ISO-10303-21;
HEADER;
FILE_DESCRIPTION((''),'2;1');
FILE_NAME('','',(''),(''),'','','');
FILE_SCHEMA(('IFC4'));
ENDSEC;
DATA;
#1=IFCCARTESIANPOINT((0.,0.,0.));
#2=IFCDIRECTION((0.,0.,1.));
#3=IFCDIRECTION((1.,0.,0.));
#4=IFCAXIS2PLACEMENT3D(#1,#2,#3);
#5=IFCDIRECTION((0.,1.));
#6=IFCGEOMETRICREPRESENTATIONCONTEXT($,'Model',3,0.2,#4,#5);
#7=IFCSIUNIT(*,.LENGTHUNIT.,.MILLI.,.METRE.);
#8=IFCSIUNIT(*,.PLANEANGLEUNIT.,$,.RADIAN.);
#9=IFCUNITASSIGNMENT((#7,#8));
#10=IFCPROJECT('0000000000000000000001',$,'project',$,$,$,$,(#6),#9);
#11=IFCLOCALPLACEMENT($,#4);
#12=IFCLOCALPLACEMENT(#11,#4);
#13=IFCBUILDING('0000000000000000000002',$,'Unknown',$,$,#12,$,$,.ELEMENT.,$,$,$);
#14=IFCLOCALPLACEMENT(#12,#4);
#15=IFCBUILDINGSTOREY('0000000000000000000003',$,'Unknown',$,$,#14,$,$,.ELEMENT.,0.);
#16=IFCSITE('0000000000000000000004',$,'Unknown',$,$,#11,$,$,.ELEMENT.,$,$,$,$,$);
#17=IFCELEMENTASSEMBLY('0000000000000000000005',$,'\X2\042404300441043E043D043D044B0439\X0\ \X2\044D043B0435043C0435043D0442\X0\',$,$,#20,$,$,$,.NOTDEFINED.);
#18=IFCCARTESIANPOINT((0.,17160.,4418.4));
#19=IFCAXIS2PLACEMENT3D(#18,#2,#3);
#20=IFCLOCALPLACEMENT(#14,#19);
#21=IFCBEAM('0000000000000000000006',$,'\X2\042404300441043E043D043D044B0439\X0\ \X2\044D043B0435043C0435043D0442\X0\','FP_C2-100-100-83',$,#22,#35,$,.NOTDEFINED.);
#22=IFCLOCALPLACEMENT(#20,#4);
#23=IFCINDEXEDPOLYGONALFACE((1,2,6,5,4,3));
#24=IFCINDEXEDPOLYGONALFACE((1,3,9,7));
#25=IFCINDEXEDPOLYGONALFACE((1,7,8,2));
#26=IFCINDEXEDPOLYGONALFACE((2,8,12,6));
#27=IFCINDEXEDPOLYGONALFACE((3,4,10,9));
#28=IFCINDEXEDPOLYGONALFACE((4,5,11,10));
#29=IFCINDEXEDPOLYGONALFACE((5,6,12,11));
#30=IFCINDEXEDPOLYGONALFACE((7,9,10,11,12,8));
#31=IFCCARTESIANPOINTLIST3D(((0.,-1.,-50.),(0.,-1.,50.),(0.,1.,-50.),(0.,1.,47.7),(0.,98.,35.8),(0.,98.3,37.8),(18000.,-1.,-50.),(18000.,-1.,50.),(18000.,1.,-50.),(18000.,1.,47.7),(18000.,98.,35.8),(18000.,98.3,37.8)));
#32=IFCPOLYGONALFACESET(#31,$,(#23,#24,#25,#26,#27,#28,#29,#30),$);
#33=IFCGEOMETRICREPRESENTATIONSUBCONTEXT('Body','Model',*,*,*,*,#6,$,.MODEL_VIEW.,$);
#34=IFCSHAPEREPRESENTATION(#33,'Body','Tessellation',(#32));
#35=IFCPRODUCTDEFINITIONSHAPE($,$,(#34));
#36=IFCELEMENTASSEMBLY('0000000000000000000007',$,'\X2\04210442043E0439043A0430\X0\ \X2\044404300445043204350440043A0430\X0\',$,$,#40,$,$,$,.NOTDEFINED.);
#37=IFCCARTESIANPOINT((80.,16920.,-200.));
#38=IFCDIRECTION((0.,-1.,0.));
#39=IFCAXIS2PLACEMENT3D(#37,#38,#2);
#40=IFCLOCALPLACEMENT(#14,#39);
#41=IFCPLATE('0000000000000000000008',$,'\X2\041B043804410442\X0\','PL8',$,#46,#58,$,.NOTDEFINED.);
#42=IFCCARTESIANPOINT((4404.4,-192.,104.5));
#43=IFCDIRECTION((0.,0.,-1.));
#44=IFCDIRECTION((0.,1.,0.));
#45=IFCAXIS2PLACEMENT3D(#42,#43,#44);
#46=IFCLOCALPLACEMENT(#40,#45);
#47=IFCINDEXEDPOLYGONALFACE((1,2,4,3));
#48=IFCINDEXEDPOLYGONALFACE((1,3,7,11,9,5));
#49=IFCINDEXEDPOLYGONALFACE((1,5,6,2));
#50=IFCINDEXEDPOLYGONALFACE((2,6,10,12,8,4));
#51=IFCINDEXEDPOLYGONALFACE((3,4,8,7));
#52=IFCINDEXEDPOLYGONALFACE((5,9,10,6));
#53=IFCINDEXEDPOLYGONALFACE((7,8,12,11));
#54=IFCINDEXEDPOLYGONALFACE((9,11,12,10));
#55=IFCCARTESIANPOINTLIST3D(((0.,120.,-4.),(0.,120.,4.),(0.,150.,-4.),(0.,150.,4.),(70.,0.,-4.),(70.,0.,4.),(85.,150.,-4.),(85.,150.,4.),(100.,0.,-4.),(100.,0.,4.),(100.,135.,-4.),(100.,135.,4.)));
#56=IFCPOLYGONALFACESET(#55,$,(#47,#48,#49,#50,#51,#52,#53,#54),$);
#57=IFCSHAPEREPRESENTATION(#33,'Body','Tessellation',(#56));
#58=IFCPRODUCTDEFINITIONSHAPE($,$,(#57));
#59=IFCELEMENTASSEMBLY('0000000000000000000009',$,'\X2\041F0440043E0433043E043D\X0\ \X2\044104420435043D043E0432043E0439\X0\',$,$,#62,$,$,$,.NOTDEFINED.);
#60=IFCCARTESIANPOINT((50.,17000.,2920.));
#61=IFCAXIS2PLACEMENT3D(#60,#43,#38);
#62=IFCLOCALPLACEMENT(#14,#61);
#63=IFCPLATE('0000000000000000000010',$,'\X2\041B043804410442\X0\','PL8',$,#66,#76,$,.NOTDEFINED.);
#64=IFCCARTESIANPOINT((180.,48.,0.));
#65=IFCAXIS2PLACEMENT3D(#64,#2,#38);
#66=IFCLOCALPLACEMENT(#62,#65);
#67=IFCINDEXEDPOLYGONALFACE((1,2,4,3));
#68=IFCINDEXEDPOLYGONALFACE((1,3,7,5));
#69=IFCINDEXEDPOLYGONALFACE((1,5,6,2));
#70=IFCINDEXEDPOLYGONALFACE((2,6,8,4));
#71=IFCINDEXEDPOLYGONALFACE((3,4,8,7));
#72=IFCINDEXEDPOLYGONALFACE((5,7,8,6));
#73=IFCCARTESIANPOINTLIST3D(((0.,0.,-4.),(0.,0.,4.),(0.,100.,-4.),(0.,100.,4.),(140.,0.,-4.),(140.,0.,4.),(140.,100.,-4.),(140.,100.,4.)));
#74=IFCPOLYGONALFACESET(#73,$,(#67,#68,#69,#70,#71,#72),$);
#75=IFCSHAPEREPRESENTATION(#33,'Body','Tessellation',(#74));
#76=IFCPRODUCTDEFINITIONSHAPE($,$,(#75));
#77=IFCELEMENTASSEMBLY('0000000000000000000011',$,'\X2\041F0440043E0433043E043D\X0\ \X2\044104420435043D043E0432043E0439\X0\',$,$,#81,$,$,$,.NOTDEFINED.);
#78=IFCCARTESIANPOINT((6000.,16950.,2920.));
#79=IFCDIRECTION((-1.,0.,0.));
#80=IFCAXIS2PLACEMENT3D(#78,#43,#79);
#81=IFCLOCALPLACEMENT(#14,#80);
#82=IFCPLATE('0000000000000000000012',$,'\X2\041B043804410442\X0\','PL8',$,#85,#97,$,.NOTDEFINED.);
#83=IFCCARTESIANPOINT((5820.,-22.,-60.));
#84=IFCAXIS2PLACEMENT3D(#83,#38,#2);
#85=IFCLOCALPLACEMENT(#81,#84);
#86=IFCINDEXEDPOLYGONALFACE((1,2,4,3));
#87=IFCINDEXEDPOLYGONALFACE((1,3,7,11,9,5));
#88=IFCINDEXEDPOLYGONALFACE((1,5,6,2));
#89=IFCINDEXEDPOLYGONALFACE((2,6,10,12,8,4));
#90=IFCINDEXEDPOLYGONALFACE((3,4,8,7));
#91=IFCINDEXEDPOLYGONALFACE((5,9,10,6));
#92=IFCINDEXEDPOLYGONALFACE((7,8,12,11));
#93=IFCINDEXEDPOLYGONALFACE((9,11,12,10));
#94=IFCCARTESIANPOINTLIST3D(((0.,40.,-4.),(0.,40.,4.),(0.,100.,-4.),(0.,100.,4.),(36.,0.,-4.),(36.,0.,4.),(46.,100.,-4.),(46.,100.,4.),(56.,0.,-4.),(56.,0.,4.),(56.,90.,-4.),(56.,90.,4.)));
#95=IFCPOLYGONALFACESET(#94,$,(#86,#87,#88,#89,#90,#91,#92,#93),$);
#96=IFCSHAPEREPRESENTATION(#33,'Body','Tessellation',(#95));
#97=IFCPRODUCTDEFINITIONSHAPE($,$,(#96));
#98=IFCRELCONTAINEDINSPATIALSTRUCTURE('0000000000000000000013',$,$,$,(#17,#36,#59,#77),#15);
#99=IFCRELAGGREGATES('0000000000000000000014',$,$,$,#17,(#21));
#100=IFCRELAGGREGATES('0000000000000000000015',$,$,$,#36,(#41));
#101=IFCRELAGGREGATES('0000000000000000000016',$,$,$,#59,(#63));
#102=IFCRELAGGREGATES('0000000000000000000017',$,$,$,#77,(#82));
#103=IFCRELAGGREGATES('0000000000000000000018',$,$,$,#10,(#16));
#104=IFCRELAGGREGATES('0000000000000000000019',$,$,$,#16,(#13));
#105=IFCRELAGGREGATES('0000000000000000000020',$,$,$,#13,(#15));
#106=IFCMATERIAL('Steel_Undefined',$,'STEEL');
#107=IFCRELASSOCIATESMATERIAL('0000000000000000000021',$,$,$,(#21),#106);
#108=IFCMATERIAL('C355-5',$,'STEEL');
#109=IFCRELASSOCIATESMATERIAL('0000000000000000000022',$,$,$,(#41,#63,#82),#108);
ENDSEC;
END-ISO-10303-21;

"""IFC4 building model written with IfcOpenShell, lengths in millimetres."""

from ifc_helpers import new_model, si_unit, direction, frame, origin_with_axes, place, context, subcontext, project, spatial, line, indexed_curve, outline, extrude, material, element, aggregate, save


model = new_model("IFC4")

# Units and contexts
model_context = context("Model", 3, precision=0.2, world=origin_with_axes(), true_north=direction((0.0, 1.0)))
body_context = subcontext(model_context, "Body", "Model", "MODEL_VIEW")
ifc_project = project(units=[si_unit("LENGTHUNIT", "METRE", prefix="MILLI"), si_unit("PLANEANGLEUNIT", "RADIAN")], contexts=[model_context])

# Site, building, storey
site_placement = place(None, origin_with_axes())
site = spatial("IfcSite", under=ifc_project, at=site_placement, Name="Unknown", CompositionType="ELEMENT")
building_placement = place(site_placement, origin_with_axes())
building = spatial("IfcBuilding", under=site, at=building_placement, Name="Unknown", CompositionType="ELEMENT")
storey_placement = place(building_placement, origin_with_axes())
storey = spatial("IfcBuildingStorey", under=building, at=storey_placement, Name="Unknown", CompositionType="ELEMENT", Elevation=0.0)

# Element assembly, beam
ifc_material_1 = material(Name="Steel_Undefined", Category="STEEL")
assembly_1_placement = place(storey_placement, frame((0.0, 17160.0, 4418.4), z_axis=(0.0, 0.0, 1.0), x_axis=(1.0, 0.0, 0.0)))
assembly_1 = element("IfcElementAssembly", 1, at=assembly_1_placement, inside=storey, Name="Фасонный элемент", PredefinedType="NOTDEFINED")
beam_1_placement = place(assembly_1_placement, origin_with_axes())
beam_1 = element("IfcBeam", 2, at=beam_1_placement, material=ifc_material_1, Name="Фасонный элемент", Description="FP_C2-100-100-83", PredefinedType="NOTDEFINED", context=body_context, shape_type="SolidModel", body=[
    extrude(outline(indexed_curve([(-50.0, -1.0), (50.0, -1.0), (37.8, 98.3), (35.8, 98.0), (47.7, 1.0), (-50.0, 1.0)], segments=[line(1, 2, 3, 4, 5, 6, 1)])), frame((0.0, 0.0, 0.0), z_axis=(-1.0, 0.0, 0.0), x_axis=(0.0, 0.0, 1.0)), (0.0, 0.0, -1.0), 18000.0),
])
aggregate(assembly_1, [beam_1])

# Element assembly, plate
assembly_2_placement = place(storey_placement, frame((80.0, 16920.0, -200.0), z_axis=(0.0, -1.0, 0.0), x_axis=(0.0, 0.0, 1.0)))
assembly_2 = element("IfcElementAssembly", 3, at=assembly_2_placement, inside=storey, Name="Стойка фахверка", PredefinedType="NOTDEFINED")
ifc_material_2 = material(Name="C355-5", Category="STEEL")
plate_1_placement = place(assembly_2_placement, frame((4404.4, -192.0, 104.5), z_axis=(0.0, 0.0, -1.0), x_axis=(0.0, 1.0, 0.0)))
plate_1 = element("IfcPlate", 4, at=plate_1_placement, material=ifc_material_2, Name="Лист", Description="PL8", PredefinedType="NOTDEFINED", context=body_context, shape_type="SolidModel", body=[
    extrude(outline(indexed_curve([(0.0, 120.0), (70.0, 0.0), (100.0, 0.0), (100.0, 135.0), (85.0, 150.0), (0.0, 150.0)], segments=[line(1, 2, 3, 4, 5, 6, 1)])), frame((0.0, 0.0, 4.0), z_axis=(0.0, 0.0, 1.0), x_axis=(1.0, 0.0, 0.0)), (0.0, 0.0, -1.0), 8.0),
])
aggregate(assembly_2, [plate_1])

# Element assemblies, plates
assembly_3_placement = place(storey_placement, frame((50.0, 17000.0, 2920.0), z_axis=(0.0, 0.0, -1.0), x_axis=(0.0, -1.0, 0.0)))
assembly_3 = element("IfcElementAssembly", 5, at=assembly_3_placement, inside=storey, Name="Прогон стеновой", PredefinedType="NOTDEFINED")
plate_2_placement = place(assembly_3_placement, frame((180.0, 48.0, 0.0), z_axis=(0.0, 0.0, 1.0), x_axis=(0.0, -1.0, 0.0)))
plate_2 = element("IfcPlate", 6, at=plate_2_placement, material=ifc_material_2, Name="Лист", Description="PL8", PredefinedType="NOTDEFINED", context=body_context, shape_type="SolidModel", body=[
    extrude(outline(indexed_curve([(0.0, 0.0), (140.0, 0.0), (140.0, 100.0), (0.0, 100.0)], segments=[line(1, 2, 3, 4, 1)])), frame((0.0, 0.0, 4.0), z_axis=(0.0, 0.0, 1.0), x_axis=(1.0, 0.0, 0.0)), (0.0, 0.0, -1.0), 8.0),
])
aggregate(assembly_3, [plate_2])
assembly_4_placement = place(storey_placement, frame((6000.0, 16950.0, 2920.0), z_axis=(0.0, 0.0, -1.0), x_axis=(-1.0, 0.0, 0.0)))
assembly_4 = element("IfcElementAssembly", 7, at=assembly_4_placement, inside=storey, Name="Прогон стеновой", PredefinedType="NOTDEFINED")
plate_3_placement = place(assembly_4_placement, frame((5820.0, -22.0, -60.0), z_axis=(0.0, -1.0, 0.0), x_axis=(0.0, 0.0, 1.0)))
plate_3 = element("IfcPlate", 8, at=plate_3_placement, material=ifc_material_2, Name="Лист", Description="PL8", PredefinedType="NOTDEFINED", context=body_context, shape_type="SolidModel", body=[
    extrude(outline(indexed_curve([(0.0, 40.0), (36.0, 0.0), (56.0, 0.0), (56.0, 90.0), (46.0, 100.0), (0.0, 100.0)], segments=[line(1, 2, 3, 4, 5, 6, 1)])), frame((0.0, 0.0, 4.0), z_axis=(0.0, 0.0, 1.0), x_axis=(1.0, 0.0, 0.0)), (0.0, 0.0, -1.0), 8.0),
])
aggregate(assembly_4, [plate_3])

save(model, "model.ifc")
